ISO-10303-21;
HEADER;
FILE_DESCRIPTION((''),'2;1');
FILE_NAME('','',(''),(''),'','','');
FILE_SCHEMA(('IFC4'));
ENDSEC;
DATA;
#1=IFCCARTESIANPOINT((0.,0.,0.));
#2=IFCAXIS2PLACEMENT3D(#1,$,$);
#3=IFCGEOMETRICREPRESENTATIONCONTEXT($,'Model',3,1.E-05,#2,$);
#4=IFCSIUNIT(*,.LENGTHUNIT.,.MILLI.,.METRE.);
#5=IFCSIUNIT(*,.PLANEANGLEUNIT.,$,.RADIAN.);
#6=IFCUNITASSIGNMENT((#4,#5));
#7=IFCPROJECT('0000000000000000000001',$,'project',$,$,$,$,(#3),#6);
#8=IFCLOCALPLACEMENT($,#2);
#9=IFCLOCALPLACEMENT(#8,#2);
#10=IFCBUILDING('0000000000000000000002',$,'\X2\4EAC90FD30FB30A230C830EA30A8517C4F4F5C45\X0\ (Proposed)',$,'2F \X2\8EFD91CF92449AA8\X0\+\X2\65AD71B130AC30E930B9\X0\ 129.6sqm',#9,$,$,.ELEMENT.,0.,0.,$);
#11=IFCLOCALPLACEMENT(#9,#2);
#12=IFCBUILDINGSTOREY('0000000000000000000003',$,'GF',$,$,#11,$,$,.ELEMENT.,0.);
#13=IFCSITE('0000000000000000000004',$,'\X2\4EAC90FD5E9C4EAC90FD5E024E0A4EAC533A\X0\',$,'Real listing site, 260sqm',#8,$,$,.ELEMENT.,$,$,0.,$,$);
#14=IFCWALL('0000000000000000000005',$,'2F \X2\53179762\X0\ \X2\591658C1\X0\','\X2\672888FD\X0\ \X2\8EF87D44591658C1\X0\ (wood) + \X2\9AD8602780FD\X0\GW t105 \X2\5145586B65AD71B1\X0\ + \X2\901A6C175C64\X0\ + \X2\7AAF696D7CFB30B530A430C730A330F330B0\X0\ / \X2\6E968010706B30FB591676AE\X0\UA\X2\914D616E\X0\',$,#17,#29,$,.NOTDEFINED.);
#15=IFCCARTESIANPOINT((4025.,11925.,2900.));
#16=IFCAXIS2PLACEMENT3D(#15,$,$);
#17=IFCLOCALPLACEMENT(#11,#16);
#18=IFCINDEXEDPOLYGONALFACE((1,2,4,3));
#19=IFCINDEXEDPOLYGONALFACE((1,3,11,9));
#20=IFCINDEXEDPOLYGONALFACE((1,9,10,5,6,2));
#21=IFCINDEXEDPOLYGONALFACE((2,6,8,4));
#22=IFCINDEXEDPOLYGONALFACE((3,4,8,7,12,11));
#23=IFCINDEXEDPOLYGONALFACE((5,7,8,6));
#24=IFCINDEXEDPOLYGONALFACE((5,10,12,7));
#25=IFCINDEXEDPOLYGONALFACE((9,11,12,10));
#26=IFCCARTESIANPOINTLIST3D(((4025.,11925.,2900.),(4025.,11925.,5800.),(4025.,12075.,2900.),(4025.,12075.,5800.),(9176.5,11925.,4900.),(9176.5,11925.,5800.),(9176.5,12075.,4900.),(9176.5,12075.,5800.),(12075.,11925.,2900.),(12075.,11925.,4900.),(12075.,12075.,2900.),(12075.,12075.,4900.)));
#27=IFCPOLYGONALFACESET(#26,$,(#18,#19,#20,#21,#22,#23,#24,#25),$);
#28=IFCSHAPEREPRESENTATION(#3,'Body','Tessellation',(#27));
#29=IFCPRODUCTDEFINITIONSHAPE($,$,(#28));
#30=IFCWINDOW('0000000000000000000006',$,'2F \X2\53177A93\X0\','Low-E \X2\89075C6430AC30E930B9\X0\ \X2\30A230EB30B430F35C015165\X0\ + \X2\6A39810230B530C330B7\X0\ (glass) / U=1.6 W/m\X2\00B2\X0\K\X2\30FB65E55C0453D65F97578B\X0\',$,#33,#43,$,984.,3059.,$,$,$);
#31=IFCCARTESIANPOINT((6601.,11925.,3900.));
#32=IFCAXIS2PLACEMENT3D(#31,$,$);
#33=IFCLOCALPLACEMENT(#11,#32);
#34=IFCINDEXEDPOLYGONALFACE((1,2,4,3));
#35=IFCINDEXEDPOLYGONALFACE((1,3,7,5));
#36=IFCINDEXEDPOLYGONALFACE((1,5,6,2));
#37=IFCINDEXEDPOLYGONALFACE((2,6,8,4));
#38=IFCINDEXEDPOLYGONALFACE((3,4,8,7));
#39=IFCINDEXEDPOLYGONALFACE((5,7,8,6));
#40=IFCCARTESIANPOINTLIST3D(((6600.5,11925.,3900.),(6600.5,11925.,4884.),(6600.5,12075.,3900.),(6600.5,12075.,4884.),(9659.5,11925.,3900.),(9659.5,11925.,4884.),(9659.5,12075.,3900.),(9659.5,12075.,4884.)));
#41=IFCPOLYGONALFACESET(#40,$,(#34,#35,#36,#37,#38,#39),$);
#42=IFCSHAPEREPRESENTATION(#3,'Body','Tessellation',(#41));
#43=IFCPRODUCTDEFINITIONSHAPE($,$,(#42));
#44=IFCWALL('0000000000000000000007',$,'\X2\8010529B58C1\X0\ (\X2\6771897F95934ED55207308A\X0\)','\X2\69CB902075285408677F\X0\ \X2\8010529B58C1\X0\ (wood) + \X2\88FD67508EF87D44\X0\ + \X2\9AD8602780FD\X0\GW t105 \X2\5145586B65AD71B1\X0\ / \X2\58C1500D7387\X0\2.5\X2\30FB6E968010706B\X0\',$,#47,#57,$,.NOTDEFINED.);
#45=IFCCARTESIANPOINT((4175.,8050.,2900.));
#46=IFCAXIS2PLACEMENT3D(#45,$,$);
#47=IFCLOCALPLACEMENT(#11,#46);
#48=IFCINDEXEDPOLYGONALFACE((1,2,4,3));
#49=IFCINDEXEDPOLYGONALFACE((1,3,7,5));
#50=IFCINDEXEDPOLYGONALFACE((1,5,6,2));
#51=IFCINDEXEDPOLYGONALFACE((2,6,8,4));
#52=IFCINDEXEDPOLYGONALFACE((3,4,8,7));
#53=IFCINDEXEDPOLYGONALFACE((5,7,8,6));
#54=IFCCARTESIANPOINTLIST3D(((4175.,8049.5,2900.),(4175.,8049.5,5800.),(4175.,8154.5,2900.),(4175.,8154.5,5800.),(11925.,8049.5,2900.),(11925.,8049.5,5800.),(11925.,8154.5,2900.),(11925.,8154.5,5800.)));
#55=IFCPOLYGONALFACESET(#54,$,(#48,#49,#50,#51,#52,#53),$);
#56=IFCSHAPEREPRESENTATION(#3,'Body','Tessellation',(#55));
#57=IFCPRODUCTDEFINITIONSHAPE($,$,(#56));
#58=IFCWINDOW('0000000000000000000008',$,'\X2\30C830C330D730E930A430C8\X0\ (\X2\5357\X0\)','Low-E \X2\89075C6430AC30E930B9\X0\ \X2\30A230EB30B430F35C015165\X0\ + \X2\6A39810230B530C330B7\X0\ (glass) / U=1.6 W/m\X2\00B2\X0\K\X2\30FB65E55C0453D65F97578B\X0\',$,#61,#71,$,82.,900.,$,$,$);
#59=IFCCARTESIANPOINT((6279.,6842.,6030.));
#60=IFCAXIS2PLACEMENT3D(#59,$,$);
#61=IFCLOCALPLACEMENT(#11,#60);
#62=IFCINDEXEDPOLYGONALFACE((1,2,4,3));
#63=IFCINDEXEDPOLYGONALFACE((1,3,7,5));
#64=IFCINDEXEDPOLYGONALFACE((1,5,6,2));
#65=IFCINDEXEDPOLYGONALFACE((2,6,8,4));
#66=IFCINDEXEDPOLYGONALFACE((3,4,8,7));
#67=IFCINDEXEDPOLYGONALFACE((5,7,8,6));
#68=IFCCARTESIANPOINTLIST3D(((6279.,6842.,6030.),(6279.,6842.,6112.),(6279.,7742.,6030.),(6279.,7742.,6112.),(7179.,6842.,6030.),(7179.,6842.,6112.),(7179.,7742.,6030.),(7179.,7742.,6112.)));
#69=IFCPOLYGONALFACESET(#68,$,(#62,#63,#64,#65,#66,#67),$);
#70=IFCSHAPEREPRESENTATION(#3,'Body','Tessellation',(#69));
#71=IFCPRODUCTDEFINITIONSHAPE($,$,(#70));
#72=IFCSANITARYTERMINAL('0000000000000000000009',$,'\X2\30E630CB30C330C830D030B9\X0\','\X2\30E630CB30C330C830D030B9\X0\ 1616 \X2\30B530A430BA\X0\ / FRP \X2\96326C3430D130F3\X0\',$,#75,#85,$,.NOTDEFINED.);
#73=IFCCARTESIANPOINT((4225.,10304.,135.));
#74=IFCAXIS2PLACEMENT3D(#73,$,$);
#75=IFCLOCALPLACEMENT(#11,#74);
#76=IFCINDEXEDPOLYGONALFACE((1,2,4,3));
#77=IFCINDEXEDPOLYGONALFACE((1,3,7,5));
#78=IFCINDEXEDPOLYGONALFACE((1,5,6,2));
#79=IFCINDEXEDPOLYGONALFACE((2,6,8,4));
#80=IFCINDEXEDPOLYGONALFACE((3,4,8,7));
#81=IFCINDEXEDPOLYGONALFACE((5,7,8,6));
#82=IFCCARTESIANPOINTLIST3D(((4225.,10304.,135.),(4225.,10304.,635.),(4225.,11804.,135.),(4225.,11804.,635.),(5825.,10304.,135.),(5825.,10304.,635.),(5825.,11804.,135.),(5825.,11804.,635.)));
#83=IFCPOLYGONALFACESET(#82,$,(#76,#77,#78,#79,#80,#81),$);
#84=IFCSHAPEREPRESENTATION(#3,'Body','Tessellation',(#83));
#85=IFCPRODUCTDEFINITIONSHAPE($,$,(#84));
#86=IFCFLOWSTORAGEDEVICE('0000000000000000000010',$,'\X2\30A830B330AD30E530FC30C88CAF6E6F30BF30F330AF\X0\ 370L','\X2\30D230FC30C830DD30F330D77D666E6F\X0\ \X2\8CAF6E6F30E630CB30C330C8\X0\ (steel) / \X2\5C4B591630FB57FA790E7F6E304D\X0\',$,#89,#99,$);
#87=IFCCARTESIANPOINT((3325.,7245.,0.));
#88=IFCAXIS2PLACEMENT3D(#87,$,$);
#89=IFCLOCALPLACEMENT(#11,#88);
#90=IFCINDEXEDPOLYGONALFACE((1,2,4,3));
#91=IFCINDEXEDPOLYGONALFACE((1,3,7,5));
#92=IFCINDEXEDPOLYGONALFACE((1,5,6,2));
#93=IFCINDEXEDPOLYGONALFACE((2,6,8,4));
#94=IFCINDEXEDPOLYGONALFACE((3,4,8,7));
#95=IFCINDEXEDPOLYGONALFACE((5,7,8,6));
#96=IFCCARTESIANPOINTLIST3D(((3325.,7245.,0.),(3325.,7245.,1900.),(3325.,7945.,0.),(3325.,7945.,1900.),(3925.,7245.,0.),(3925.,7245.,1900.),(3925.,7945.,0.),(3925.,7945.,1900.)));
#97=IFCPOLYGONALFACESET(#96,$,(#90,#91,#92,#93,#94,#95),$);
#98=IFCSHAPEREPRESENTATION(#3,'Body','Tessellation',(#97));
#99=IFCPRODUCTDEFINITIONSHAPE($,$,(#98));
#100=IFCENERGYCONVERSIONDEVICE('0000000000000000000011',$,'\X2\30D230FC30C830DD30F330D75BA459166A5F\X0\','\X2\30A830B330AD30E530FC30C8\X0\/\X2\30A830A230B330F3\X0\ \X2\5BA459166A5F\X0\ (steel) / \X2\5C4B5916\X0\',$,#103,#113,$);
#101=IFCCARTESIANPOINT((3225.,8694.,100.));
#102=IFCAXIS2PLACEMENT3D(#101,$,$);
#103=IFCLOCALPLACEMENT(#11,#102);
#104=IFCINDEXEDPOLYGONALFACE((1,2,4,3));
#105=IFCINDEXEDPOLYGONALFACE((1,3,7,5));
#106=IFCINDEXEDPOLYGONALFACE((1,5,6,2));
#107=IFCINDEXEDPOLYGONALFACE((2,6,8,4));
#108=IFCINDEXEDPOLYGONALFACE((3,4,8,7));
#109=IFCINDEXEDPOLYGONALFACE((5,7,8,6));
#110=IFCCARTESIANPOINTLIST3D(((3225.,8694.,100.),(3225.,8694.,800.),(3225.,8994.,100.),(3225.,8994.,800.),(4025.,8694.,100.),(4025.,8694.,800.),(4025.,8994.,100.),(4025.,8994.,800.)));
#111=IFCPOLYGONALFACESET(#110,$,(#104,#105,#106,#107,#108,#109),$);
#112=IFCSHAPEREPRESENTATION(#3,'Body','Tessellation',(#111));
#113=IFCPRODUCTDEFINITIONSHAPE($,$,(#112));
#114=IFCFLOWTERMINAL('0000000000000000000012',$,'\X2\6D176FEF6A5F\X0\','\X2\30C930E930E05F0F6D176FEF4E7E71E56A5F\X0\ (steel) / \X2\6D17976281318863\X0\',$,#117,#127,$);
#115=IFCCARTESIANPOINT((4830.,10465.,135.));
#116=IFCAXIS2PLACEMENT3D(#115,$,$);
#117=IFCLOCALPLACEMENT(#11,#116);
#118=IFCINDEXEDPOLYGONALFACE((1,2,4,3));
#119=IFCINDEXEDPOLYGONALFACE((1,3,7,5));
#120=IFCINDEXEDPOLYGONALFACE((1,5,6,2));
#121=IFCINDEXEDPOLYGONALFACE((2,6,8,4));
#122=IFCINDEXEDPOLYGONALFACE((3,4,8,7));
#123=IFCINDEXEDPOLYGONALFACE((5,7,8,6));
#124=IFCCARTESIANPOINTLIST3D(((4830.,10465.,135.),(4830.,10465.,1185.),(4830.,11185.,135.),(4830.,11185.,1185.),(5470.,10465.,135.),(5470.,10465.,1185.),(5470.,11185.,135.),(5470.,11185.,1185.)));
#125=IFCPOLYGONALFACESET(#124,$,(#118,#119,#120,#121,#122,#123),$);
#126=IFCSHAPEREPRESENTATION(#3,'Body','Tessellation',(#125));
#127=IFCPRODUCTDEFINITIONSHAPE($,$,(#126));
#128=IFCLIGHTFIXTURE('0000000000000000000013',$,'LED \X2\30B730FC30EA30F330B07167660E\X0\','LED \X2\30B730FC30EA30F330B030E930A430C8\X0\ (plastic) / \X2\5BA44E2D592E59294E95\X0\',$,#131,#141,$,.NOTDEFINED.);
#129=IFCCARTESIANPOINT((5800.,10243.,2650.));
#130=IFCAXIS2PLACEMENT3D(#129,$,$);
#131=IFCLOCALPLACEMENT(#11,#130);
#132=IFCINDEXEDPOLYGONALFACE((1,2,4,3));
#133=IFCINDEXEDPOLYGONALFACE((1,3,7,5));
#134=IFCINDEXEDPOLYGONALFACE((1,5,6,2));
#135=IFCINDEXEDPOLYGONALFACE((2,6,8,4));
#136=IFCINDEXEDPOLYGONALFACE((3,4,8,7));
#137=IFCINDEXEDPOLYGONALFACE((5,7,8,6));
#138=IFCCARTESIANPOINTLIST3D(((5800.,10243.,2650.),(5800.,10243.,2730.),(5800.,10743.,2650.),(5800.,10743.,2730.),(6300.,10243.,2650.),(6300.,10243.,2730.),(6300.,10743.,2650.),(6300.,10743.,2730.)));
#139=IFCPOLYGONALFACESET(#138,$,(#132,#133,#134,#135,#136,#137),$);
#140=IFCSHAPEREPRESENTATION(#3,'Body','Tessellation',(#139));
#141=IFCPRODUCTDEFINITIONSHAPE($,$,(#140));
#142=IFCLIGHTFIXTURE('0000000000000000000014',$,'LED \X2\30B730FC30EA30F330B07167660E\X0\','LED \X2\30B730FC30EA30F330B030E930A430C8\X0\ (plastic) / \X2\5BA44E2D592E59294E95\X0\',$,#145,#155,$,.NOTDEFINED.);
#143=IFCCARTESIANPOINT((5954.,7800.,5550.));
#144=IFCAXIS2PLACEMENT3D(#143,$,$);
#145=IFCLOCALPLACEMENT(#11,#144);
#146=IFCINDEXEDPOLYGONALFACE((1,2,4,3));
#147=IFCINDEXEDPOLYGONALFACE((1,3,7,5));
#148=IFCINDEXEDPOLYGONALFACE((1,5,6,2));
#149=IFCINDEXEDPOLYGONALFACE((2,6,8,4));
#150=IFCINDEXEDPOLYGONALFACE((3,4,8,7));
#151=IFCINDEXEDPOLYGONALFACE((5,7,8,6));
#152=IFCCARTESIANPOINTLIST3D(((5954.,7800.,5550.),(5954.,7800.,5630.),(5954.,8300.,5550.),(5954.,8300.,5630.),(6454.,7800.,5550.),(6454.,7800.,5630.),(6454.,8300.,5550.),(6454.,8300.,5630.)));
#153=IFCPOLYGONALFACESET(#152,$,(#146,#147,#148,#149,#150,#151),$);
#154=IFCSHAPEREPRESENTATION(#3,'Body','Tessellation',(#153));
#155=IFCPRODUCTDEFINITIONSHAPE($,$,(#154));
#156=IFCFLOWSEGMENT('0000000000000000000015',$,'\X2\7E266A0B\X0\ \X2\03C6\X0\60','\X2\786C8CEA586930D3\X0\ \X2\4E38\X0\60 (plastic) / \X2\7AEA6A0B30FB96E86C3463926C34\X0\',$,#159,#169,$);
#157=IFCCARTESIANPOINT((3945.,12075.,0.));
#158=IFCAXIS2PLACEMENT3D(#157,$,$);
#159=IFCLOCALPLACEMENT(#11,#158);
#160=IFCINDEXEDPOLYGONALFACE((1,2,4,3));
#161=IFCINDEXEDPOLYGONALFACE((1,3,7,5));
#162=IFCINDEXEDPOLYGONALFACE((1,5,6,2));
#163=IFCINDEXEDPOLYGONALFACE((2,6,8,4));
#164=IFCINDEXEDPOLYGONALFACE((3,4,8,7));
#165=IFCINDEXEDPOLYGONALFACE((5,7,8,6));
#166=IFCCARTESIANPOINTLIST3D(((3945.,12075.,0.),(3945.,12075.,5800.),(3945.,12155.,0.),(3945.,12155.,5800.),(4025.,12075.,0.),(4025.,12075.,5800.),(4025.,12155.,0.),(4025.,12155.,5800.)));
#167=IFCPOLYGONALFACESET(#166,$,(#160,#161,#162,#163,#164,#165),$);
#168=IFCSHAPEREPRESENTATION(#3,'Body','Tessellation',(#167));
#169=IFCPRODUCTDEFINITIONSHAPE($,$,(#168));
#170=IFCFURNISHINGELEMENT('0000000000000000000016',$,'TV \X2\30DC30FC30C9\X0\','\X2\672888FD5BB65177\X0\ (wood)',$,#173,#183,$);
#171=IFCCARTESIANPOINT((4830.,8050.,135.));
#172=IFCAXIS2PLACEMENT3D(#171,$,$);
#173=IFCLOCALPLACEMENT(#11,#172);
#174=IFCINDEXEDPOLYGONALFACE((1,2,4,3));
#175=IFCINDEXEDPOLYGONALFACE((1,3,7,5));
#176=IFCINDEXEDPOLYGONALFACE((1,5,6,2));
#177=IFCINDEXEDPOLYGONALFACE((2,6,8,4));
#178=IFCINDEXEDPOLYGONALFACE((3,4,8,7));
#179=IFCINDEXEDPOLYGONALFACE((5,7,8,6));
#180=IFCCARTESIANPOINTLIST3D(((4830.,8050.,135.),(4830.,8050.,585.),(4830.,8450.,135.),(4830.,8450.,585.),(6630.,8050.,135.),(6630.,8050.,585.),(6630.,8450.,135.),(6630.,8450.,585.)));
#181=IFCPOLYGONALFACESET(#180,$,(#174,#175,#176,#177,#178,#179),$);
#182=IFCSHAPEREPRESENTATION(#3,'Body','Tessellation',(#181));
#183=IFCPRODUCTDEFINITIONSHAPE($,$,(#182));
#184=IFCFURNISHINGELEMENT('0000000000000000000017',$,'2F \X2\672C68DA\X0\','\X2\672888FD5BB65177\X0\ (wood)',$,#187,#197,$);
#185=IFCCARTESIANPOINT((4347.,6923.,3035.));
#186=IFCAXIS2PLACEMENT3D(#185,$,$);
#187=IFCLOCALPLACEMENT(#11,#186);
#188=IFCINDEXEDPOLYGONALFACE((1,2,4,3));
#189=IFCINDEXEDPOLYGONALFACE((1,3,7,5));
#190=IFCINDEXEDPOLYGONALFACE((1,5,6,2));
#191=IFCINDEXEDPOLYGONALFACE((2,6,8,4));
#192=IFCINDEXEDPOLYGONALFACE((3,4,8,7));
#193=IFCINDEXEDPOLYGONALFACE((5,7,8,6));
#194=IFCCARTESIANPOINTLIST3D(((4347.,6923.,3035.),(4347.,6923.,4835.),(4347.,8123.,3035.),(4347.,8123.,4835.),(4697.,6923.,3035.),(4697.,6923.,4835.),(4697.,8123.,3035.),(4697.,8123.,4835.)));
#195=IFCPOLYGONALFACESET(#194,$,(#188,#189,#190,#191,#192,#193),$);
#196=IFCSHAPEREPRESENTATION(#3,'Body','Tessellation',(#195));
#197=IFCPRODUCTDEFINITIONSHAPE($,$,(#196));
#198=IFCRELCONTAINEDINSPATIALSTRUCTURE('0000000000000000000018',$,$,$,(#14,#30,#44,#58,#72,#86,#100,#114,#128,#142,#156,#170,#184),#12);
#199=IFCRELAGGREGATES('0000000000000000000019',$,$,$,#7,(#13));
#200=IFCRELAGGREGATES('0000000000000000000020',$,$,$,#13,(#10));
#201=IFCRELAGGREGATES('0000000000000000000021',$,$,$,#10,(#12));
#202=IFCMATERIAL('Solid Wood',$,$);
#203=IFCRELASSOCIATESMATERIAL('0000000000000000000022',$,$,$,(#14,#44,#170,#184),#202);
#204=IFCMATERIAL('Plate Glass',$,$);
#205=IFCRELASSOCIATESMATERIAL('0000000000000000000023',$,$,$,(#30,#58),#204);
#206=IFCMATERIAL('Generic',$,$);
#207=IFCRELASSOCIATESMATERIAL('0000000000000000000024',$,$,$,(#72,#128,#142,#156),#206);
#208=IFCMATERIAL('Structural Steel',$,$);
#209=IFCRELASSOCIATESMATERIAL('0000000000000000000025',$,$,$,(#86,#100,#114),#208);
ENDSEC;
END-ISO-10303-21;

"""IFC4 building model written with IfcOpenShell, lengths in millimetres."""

from ifc_helpers import new_model, si_unit, frame, frame_2d, origin, place, context, project, spatial, rectangle, extrude, material, element, fill, save


model = new_model("IFC4")

# Units and contexts
model_context = context("Model", 3, precision=1e-05, world=origin())
ifc_project = project(units=[si_unit("LENGTHUNIT", "METRE", prefix="MILLI"), si_unit("PLANEANGLEUNIT", "RADIAN")], contexts=[model_context])

# Site, building, storey
site_placement = place(None, origin())
site = spatial("IfcSite", under=ifc_project, at=site_placement, Name="京都府京都市上京区", ObjectType="Real listing site, 260sqm", CompositionType="ELEMENT", RefElevation=0.0)
building_placement = place(site_placement, origin())
building = spatial("IfcBuilding", under=site, at=building_placement, Name="京都・アトリエ兼住居 (Proposed)", ObjectType="2F 軽量鉄骨+断熱ガラス 129.6sqm", CompositionType="ELEMENT", ElevationOfRefHeight=0.0, ElevationOfTerrain=0.0)
storey_placement = place(building_placement, origin())
storey = spatial("IfcBuildingStorey", under=building, at=storey_placement, Name="GF", CompositionType="ELEMENT", Elevation=0.0)

# Shared definitions
ifc_material_1 = material(Name="Solid Wood")

# Shared definitions
ifc_material_2 = material(Name="Plate Glass")

# Wall, opening, window
wall_1_placement = place(storey_placement, frame((4025.0, 11925.0, 2900.0)))
wall_1 = element("IfcWall", 1, at=wall_1_placement, inside=storey, material=ifc_material_1, Name="2F 北面 外壁", Description="木製 軸組外壁 (wood) + 高性能GW t105 充填断熱 + 通気層 + 窯業系サイディング / 準耐火・外皮UA配慮", PredefinedType="NOTDEFINED", context=model_context, shape_type="SweptSolid", body=[
    extrude(rectangle(XDim=8050.0, YDim=150.0, at=frame_2d((4025.0, 75.0))), frame((4025.0, 11925.0, 2900.0)), (0.0, 0.0, 1.0), 2900.0),
])
opening_1_placement = place(storey_placement, frame((6601.0, 11925.0, 3900.0)))
opening_1 = element("IfcOpeningElement", 2, at=opening_1_placement, cuts=wall_1, PredefinedType="NOTDEFINED", context=model_context, shape_type="SweptSolid", body=[
    extrude(rectangle(XDim=3059.0, YDim=150.0, at=frame_2d((1529.0, 75.0))), frame((6601.0, 11925.0, 3900.0)), (0.0, 0.0, 1.0), 984.0),
])
window_1_placement = place(storey_placement, frame((6601.0, 11925.0, 3900.0)))
window_1 = element("IfcWindow", 3, at=window_1_placement, inside=storey, material=ifc_material_2, Name="2F 北窓", Description="Low-E 複層ガラス アルゴン封入 + 樹脂サッシ (glass) / U=1.6 W/m²K・日射取得型", OverallHeight=984.0, OverallWidth=3059.0, context=model_context, shape_type="SweptSolid", body=[
    extrude(rectangle(XDim=3059.0, YDim=150.0, at=frame_2d((1529.0, 75.0))), frame((6601.0, 11925.0, 3900.0)), (0.0, 0.0, 1.0), 984.0),
])
fill(opening_1, window_1)

# Wall
wall_2_placement = place(storey_placement, frame((4175.0, 8050.0, 2900.0)))
element("IfcWall", 4, at=wall_2_placement, inside=storey, material=ifc_material_1, Name="耐力壁 (東西間仕切り)", Description="構造用合板 耐力壁 (wood) + 製材軸組 + 高性能GW t105 充填断熱 / 壁倍率2.5・準耐火", PredefinedType="NOTDEFINED", context=model_context, shape_type="SweptSolid", body=[
    extrude(rectangle(XDim=7750.0, YDim=105.0, at=frame_2d((3875.0, 52.0))), frame((4175.0, 8050.0, 2900.0)), (0.0, 0.0, 1.0), 2900.0),
])

# Window
window_2_placement = place(storey_placement, frame((6279.0, 6842.0, 6030.0)))
element("IfcWindow", 5, at=window_2_placement, inside=storey, material=ifc_material_2, Name="トップライト (南)", Description="Low-E 複層ガラス アルゴン封入 + 樹脂サッシ (glass) / U=1.6 W/m²K・日射取得型", OverallHeight=82.0, OverallWidth=900.0, context=model_context, shape_type="SweptSolid", body=[
    extrude(rectangle(XDim=900.0, YDim=900.0, at=frame_2d((450.0, 450.0))), frame((6279.0, 6842.0, 6030.0)), (0.0, 0.0, 1.0), 82.0),
])

# Sanitary terminal
ifc_material_3 = material(Name="Generic")
sanitary_terminal_placement = place(storey_placement, frame((4225.0, 10304.0, 135.0)))
element("IfcSanitaryTerminal", 6, at=sanitary_terminal_placement, inside=storey, material=ifc_material_3, Name="ユニットバス", Description="ユニットバス 1616 サイズ / FRP 防水パン", PredefinedType="NOTDEFINED", context=model_context, shape_type="SweptSolid", body=[
    extrude(rectangle(XDim=1600.0, YDim=1500.0, at=frame_2d((800.0, 750.0))), frame((4225.0, 10304.0, 135.0)), (0.0, 0.0, 1.0), 500.0),
])

# Flow storage device
ifc_material_4 = material(Name="Structural Steel")
flow_storage_device_placement = place(storey_placement, frame((3325.0, 7245.0, 0.0)))
element("IfcFlowStorageDevice", 7, at=flow_storage_device_placement, inside=storey, material=ifc_material_4, Name="エコキュート貯湯タンク 370L", Description="ヒートポンプ給湯 貯湯ユニット (steel) / 屋外・基礎置き", context=model_context, shape_type="SweptSolid", body=[
    extrude(rectangle(XDim=600.0, YDim=700.0, at=frame_2d((300.0, 350.0))), frame((3325.0, 7245.0, 0.0)), (0.0, 0.0, 1.0), 1900.0),
])

# Energy conversion device
energy_conversion_device_placement = place(storey_placement, frame((3225.0, 8694.0, 100.0)))
element("IfcEnergyConversionDevice", 8, at=energy_conversion_device_placement, inside=storey, material=ifc_material_4, Name="ヒートポンプ室外機", Description="エコキュート/エアコン 室外機 (steel) / 屋外", context=model_context, shape_type="SweptSolid", body=[
    extrude(rectangle(XDim=800.0, YDim=300.0, at=frame_2d((400.0, 150.0))), frame((3225.0, 8694.0, 100.0)), (0.0, 0.0, 1.0), 700.0),
])

# Flow terminal
flow_terminal_placement = place(storey_placement, frame((4830.0, 10465.0, 135.0)))
element("IfcFlowTerminal", 9, at=flow_terminal_placement, inside=storey, material=ifc_material_4, Name="洗濯機", Description="ドラム式洗濯乾燥機 (steel) / 洗面脱衣", context=model_context, shape_type="SweptSolid", body=[
    extrude(rectangle(XDim=640.0, YDim=720.0, at=frame_2d((320.0, 360.0))), frame((4830.0, 10465.0, 135.0)), (0.0, 0.0, 1.0), 1050.0),
])

# Light fixtures
light_fixture_1_placement = place(storey_placement, frame((5800.0, 10243.0, 2650.0)))
element("IfcLightFixture", 10, at=light_fixture_1_placement, inside=storey, material=ifc_material_3, Name="LED シーリング照明", Description="LED シーリングライト (plastic) / 室中央天井", PredefinedType="NOTDEFINED", context=model_context, shape_type="SweptSolid", body=[
    extrude(rectangle(XDim=500.0, YDim=500.0, at=frame_2d((250.0, 250.0))), frame((5800.0, 10243.0, 2650.0)), (0.0, 0.0, 1.0), 80.0),
])
light_fixture_2_placement = place(storey_placement, frame((5954.0, 7800.0, 5550.0)))
element("IfcLightFixture", 11, at=light_fixture_2_placement, inside=storey, material=ifc_material_3, Name="LED シーリング照明", Description="LED シーリングライト (plastic) / 室中央天井", PredefinedType="NOTDEFINED", context=model_context, shape_type="SweptSolid", body=[
    extrude(rectangle(XDim=500.0, YDim=500.0, at=frame_2d((250.0, 250.0))), frame((5954.0, 7800.0, 5550.0)), (0.0, 0.0, 1.0), 80.0),
])

# Flow segment
flow_segment_1_placement = place(storey_placement, frame((3945.0, 12075.0, 0.0)))
element("IfcFlowSegment", 12, at=flow_segment_1_placement, inside=storey, material=ifc_material_3, Name="縦樋 φ60", Description="硬質塩ビ 丸60 (plastic) / 竪樋・雨水排水", context=model_context, shape_type="SweptSolid", body=[
    extrude(rectangle(XDim=80.0, YDim=80.0, at=frame_2d((40.0, 40.0))), frame((3945.0, 12075.0, 0.0)), (0.0, 0.0, 1.0), 5800.0),
])

# Furnishing elements
furnishing_1_placement = place(storey_placement, frame((4830.0, 8050.0, 135.0)))
element("IfcFurnishingElement", 13, at=furnishing_1_placement, inside=storey, material=ifc_material_1, Name="TV ボード", Description="木製家具 (wood)", context=model_context, shape_type="SweptSolid", body=[
    extrude(rectangle(XDim=1800.0, YDim=400.0, at=frame_2d((900.0, 200.0))), frame((4830.0, 8050.0, 135.0)), (0.0, 0.0, 1.0), 450.0),
])
furnishing_2_placement = place(storey_placement, frame((4347.0, 6923.0, 3035.0)))
element("IfcFurnishingElement", 14, at=furnishing_2_placement, inside=storey, material=ifc_material_1, Name="2F 本棚", Description="木製家具 (wood)", context=model_context, shape_type="SweptSolid", body=[
    extrude(rectangle(XDim=350.0, YDim=1200.0, at=frame_2d((175.0, 600.0))), frame((4347.0, 6923.0, 3035.0)), (0.0, 0.0, 1.0), 1800.0),
])

save(model, "model.ifc")
